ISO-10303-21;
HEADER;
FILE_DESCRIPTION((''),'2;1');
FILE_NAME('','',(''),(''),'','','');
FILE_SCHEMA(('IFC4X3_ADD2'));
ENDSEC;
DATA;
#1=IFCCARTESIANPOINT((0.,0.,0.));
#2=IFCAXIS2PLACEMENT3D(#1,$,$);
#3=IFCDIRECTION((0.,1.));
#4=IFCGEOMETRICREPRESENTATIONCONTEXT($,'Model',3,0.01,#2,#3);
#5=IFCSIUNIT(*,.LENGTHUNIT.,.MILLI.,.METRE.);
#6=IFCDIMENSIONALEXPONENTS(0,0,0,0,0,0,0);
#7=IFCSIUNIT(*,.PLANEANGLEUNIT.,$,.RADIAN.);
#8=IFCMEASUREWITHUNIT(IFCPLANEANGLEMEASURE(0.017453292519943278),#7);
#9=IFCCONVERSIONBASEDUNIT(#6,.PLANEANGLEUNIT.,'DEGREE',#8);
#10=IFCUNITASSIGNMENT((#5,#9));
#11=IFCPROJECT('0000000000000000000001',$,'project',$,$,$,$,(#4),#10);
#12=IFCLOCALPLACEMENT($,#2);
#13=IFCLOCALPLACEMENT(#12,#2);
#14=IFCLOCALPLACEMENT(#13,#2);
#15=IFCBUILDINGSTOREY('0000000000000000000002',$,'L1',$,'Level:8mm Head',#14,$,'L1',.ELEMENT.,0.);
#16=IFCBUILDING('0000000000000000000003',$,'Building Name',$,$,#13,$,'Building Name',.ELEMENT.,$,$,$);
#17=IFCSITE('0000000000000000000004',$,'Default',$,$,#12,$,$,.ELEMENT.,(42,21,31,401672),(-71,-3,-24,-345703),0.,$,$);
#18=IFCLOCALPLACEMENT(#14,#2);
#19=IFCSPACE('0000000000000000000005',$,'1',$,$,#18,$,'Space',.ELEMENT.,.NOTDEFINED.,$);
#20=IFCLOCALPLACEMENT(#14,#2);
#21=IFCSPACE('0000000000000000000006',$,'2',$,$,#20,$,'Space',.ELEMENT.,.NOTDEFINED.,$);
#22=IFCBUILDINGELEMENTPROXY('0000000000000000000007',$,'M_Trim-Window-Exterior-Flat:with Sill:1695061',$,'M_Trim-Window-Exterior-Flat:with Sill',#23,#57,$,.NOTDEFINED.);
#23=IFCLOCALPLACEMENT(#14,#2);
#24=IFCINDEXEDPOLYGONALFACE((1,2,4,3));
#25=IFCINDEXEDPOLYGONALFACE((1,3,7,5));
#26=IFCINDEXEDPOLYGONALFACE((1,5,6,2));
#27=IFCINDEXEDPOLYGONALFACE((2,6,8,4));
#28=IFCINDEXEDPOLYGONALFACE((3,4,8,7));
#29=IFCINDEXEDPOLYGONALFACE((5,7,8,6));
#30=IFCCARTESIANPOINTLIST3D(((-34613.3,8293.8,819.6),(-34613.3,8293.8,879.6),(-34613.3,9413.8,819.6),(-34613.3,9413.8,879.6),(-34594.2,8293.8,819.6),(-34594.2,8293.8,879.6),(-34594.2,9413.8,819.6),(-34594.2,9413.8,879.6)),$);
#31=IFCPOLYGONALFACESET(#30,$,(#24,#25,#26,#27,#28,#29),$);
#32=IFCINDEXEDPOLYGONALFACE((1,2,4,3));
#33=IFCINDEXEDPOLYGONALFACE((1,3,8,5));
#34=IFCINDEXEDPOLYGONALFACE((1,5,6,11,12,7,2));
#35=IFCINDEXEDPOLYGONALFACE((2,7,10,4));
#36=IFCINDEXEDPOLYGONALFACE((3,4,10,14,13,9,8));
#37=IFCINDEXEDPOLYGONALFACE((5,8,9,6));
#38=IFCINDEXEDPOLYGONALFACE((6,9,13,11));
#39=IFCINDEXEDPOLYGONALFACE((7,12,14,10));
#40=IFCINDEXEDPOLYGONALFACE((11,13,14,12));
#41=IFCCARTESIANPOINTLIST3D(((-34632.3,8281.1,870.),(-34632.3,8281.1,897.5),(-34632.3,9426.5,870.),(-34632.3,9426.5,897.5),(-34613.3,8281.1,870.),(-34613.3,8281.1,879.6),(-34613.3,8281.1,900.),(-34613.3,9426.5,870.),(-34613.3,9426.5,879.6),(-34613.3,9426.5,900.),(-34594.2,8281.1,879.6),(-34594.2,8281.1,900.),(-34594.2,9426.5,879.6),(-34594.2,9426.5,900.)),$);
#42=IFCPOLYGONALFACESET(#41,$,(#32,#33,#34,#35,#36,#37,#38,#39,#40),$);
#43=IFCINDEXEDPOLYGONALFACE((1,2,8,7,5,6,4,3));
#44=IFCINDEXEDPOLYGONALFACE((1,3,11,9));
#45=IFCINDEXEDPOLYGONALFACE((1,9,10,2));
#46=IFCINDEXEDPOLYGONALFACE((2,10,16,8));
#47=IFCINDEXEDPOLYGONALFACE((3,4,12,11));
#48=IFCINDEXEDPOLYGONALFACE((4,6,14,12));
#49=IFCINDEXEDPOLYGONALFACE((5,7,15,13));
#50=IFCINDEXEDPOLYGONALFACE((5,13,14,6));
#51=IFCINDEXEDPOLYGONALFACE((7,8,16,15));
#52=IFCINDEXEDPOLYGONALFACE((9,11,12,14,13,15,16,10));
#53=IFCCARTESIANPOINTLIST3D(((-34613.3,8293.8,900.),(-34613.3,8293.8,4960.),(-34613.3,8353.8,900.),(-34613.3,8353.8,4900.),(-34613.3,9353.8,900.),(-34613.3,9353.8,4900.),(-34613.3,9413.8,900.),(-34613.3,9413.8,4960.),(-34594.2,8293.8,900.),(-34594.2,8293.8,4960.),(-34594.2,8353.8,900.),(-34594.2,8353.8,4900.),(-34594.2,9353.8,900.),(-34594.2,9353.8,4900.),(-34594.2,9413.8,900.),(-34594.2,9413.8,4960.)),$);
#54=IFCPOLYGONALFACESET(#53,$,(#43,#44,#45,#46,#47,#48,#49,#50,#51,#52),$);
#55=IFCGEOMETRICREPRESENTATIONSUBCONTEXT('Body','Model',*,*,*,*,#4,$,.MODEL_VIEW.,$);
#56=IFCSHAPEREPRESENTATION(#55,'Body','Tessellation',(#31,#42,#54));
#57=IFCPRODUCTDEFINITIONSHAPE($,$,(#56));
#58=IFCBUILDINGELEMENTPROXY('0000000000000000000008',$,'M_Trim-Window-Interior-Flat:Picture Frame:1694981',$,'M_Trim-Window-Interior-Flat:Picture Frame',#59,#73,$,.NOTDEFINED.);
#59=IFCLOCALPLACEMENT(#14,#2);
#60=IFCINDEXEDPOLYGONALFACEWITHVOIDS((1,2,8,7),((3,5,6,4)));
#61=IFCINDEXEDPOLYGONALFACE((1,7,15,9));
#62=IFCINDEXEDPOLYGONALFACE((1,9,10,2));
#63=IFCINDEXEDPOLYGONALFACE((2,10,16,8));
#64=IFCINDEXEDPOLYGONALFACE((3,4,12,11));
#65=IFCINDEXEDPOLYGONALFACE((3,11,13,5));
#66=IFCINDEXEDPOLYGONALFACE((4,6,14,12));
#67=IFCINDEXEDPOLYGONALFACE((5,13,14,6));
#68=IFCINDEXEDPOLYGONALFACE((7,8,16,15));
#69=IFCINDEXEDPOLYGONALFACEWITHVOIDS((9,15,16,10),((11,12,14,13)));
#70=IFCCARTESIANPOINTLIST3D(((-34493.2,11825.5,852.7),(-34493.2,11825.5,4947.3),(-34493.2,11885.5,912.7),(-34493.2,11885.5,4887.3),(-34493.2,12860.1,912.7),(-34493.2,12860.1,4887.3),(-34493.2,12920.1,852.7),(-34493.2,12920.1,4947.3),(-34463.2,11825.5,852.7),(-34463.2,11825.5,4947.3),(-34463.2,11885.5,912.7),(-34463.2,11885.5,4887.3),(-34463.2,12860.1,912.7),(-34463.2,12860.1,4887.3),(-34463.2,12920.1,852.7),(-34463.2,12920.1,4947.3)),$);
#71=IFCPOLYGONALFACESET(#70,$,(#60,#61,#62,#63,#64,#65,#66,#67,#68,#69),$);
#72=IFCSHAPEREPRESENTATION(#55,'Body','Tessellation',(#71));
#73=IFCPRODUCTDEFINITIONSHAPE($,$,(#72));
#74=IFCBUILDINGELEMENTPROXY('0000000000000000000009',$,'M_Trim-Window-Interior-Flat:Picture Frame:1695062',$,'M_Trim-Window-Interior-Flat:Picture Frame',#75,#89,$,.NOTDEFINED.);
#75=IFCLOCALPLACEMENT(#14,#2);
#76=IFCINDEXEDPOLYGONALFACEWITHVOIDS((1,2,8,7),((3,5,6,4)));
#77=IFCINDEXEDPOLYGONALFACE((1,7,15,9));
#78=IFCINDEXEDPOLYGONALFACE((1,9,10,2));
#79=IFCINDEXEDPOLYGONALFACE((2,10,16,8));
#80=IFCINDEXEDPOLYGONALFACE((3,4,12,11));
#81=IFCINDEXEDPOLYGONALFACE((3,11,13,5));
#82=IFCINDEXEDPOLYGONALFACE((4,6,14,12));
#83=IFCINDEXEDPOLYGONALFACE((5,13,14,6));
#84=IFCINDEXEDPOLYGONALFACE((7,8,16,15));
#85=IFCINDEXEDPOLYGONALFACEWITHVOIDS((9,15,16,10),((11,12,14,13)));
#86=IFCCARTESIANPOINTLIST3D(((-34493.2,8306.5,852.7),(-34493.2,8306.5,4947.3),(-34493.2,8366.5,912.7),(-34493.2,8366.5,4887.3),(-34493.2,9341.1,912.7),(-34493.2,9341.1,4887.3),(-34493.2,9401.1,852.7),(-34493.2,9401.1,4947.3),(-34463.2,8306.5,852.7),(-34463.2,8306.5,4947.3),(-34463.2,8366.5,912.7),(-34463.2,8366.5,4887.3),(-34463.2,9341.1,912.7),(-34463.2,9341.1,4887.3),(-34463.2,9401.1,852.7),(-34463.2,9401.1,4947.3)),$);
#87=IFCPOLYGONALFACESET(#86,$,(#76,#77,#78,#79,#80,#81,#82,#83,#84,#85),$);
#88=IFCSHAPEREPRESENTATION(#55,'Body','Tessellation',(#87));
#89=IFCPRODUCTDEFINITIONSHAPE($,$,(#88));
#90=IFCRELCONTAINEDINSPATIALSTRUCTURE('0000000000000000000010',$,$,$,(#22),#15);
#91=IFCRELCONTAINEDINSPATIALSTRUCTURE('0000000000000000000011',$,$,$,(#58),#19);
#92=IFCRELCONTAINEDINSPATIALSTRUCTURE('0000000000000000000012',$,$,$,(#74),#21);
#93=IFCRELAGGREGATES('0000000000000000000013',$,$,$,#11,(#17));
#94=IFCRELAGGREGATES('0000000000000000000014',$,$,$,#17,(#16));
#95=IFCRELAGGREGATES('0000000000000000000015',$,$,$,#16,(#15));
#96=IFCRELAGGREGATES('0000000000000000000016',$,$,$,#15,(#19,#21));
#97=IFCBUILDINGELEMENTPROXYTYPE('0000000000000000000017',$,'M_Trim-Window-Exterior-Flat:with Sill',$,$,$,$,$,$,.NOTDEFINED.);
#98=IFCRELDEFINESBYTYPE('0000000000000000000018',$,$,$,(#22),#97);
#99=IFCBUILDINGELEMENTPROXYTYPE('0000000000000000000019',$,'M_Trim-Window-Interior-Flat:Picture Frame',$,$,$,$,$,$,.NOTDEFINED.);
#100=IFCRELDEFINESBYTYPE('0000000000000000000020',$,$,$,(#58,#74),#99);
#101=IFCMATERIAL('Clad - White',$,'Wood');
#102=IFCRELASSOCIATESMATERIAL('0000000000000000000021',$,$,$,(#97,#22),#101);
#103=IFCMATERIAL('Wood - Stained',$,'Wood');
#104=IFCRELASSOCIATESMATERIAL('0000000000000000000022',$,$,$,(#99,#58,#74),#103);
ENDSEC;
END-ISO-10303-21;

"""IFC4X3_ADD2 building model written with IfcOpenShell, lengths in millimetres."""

from ifc_helpers import new_model, entity, si_unit, converted_unit, direction, frame, frame_2d, origin, place, context, subcontext, project, spatial, polyline, rectangle, outline, extrude, source, transform, mapped, material, type_object, type_shapes, element, save


model = new_model("IFC4X3_ADD2")

# Units and contexts
model_context = context("Model", 3, precision=0.01, world=origin(), true_north=direction((0.0, 1.0)))
body_context = subcontext(model_context, "Body", "Model", "MODEL_VIEW")
ifc_project = project(units=[si_unit("LENGTHUNIT", "METRE", prefix="MILLI"), converted_unit("PLANEANGLEUNIT", "DEGREE", entity("IfcPlaneAngleMeasure", 0.017453292519943278), si_unit("PLANEANGLEUNIT", "RADIAN"), dimensions=[0, 0, 0, 0, 0, 0, 0])], contexts=[model_context])

# Site, building, storey
site_placement = place(None, origin())
site = spatial("IfcSite", under=ifc_project, at=site_placement, Name="Default", CompositionType="ELEMENT", RefLatitude=(42, 21, 31, 401672), RefLongitude=(-71, -3, -24, -345703), RefElevation=0.0)
building_placement = place(site_placement, origin())
building = spatial("IfcBuilding", under=site, at=building_placement, Name="Building Name", LongName="Building Name", CompositionType="ELEMENT")
storey_placement = place(building_placement, origin())
storey = spatial("IfcBuildingStorey", under=building, at=storey_placement, Name="L1", ObjectType="Level:8mm Head", LongName="L1", CompositionType="ELEMENT", Elevation=0.0)

# Building element proxy
ifc_material_1 = material(Name="Clad - White", Category="Wood")
ifc_material_2 = material(Name="Wood - Stained", Category="Wood")
building_element_proxy_type_1 = type_object("IfcBuildingElementProxyType", Name="M_Trim-Window-Exterior-Flat:with Sill", PredefinedType="NOTDEFINED", material=ifc_material_1)
shared_shape_1 = source(origin(), body_context, "Body", "SweptSolid", [
    extrude(rectangle(XDim=1120.0, YDim=60.0, at=frame_2d((0.0, 0.0), x_axis=(1.0, 0.0))), frame((0.0, -4050.4, 0.0), z_axis=(0.0, 0.0, 1.0), x_axis=(-1.0, 0.0, 0.0)), (0.0, 0.0, 1.0), 19.0),
    extrude(outline(polyline([(-19.0, -15.2), (0.0, -15.2), (0.0, -5.7), (19.0, -5.7), (19.0, 14.8), (0.0, 14.8), (-19.0, 12.3), (-19.0, -15.2)])), frame((-572.7, -4014.8, 19.0), z_axis=(1.0, 0.0, 0.0), x_axis=(0.0, 0.0, -1.0)), (0.0, 0.0, 1.0), 1145.4),
    extrude(outline(polyline([(-2045.0, -560.0), (2015.0, -560.0), (2015.0, -500.0), (-1985.0, -500.0), (-1985.0, 500.0), (2015.0, 500.0), (2015.0, 560.0), (-2045.0, 560.0), (-2045.0, -560.0)])), frame((0.0, -1985.0, 0.0), z_axis=(0.0, 0.0, 1.0), x_axis=(0.0, -1.0, 0.0)), (0.0, 0.0, 1.0), 19.0),
])
type_shapes(building_element_proxy_type_1, [shared_shape_1])
for number, where, z_axis, x_axis, name in (
    (1, (-34594.2, 8853.8, 4900.0), (-1.0, 0.0, 0.0), (0.0, -1.0, 0.0), "M_Trim-Window-Exterior-Flat:with Sill:1695061"),
):
    element("IfcBuildingElementProxy", number, at=place(storey_placement, frame(where, z_axis=z_axis, x_axis=x_axis)), inside=storey, type_object=building_element_proxy_type_1, material=ifc_material_1, Name=name, ObjectType="M_Trim-Window-Exterior-Flat:with Sill", PredefinedType="NOTDEFINED", context=body_context, shape_type="MappedRepresentation", body=[
        mapped(shared_shape_1, transform((0.0, 0.0, 0.0), scale=1.0)),
    ])

# Shared definitions
space_1_placement = place(storey_placement, origin())
space_1 = spatial("IfcSpace", under=storey, at=space_1_placement, Name="1", LongName="Space", CompositionType="ELEMENT", PredefinedType="NOTDEFINED")

# Building element proxy
building_element_proxy_type_2 = type_object("IfcBuildingElementProxyType", Name="M_Trim-Window-Interior-Flat:Picture Frame", PredefinedType="NOTDEFINED", material=ifc_material_2)
shared_shape_2 = source(origin(), body_context, "Body", "SweptSolid", [
    extrude(outline(polyline([(-547.3, -2047.3), (547.3, -2047.3), (547.3, 2047.3), (-547.3, 2047.3), (-547.3, -2047.3)]), holes=[polyline([(-487.3, -1987.3), (-487.3, 1987.3), (487.3, 1987.3), (487.3, -1987.3), (-487.3, -1987.3)])]), frame((0.0, -2000.0, 0.0), z_axis=(0.0, 0.0, 1.0), x_axis=(-1.0, 0.0, 0.0)), (0.0, 0.0, 1.0), 30.0),
])
type_shapes(building_element_proxy_type_2, [shared_shape_2])
proxy_1_placement = place(space_1_placement, frame((-34493.2, 12372.8, 4900.0), z_axis=(1.0, 0.0, 0.0), x_axis=(0.0, 1.0, 0.0)))
element("IfcBuildingElementProxy", 2, at=proxy_1_placement, inside=space_1, type_object=building_element_proxy_type_2, material=ifc_material_2, Name="M_Trim-Window-Interior-Flat:Picture Frame:1694981", ObjectType="M_Trim-Window-Interior-Flat:Picture Frame", PredefinedType="NOTDEFINED", context=body_context, shape_type="MappedRepresentation", body=[
    mapped(shared_shape_2, transform((0.0, 0.0, 0.0), scale=1.0)),
])

# Shared definitions
space_2_placement = place(storey_placement, origin())
space_2 = spatial("IfcSpace", under=storey, at=space_2_placement, Name="2", LongName="Space", CompositionType="ELEMENT", PredefinedType="NOTDEFINED")

# Building element proxy
proxy_2_placement = place(space_2_placement, frame((-34493.2, 8853.8, 4900.0), z_axis=(1.0, 0.0, 0.0), x_axis=(0.0, 1.0, 0.0)))
element("IfcBuildingElementProxy", 3, at=proxy_2_placement, inside=space_2, type_object=building_element_proxy_type_2, material=ifc_material_2, Name="M_Trim-Window-Interior-Flat:Picture Frame:1695062", ObjectType="M_Trim-Window-Interior-Flat:Picture Frame", PredefinedType="NOTDEFINED", context=body_context, shape_type="MappedRepresentation", body=[
    mapped(shared_shape_2, transform((0.0, 0.0, 0.0), scale=1.0)),
])

save(model, "model.ifc")
